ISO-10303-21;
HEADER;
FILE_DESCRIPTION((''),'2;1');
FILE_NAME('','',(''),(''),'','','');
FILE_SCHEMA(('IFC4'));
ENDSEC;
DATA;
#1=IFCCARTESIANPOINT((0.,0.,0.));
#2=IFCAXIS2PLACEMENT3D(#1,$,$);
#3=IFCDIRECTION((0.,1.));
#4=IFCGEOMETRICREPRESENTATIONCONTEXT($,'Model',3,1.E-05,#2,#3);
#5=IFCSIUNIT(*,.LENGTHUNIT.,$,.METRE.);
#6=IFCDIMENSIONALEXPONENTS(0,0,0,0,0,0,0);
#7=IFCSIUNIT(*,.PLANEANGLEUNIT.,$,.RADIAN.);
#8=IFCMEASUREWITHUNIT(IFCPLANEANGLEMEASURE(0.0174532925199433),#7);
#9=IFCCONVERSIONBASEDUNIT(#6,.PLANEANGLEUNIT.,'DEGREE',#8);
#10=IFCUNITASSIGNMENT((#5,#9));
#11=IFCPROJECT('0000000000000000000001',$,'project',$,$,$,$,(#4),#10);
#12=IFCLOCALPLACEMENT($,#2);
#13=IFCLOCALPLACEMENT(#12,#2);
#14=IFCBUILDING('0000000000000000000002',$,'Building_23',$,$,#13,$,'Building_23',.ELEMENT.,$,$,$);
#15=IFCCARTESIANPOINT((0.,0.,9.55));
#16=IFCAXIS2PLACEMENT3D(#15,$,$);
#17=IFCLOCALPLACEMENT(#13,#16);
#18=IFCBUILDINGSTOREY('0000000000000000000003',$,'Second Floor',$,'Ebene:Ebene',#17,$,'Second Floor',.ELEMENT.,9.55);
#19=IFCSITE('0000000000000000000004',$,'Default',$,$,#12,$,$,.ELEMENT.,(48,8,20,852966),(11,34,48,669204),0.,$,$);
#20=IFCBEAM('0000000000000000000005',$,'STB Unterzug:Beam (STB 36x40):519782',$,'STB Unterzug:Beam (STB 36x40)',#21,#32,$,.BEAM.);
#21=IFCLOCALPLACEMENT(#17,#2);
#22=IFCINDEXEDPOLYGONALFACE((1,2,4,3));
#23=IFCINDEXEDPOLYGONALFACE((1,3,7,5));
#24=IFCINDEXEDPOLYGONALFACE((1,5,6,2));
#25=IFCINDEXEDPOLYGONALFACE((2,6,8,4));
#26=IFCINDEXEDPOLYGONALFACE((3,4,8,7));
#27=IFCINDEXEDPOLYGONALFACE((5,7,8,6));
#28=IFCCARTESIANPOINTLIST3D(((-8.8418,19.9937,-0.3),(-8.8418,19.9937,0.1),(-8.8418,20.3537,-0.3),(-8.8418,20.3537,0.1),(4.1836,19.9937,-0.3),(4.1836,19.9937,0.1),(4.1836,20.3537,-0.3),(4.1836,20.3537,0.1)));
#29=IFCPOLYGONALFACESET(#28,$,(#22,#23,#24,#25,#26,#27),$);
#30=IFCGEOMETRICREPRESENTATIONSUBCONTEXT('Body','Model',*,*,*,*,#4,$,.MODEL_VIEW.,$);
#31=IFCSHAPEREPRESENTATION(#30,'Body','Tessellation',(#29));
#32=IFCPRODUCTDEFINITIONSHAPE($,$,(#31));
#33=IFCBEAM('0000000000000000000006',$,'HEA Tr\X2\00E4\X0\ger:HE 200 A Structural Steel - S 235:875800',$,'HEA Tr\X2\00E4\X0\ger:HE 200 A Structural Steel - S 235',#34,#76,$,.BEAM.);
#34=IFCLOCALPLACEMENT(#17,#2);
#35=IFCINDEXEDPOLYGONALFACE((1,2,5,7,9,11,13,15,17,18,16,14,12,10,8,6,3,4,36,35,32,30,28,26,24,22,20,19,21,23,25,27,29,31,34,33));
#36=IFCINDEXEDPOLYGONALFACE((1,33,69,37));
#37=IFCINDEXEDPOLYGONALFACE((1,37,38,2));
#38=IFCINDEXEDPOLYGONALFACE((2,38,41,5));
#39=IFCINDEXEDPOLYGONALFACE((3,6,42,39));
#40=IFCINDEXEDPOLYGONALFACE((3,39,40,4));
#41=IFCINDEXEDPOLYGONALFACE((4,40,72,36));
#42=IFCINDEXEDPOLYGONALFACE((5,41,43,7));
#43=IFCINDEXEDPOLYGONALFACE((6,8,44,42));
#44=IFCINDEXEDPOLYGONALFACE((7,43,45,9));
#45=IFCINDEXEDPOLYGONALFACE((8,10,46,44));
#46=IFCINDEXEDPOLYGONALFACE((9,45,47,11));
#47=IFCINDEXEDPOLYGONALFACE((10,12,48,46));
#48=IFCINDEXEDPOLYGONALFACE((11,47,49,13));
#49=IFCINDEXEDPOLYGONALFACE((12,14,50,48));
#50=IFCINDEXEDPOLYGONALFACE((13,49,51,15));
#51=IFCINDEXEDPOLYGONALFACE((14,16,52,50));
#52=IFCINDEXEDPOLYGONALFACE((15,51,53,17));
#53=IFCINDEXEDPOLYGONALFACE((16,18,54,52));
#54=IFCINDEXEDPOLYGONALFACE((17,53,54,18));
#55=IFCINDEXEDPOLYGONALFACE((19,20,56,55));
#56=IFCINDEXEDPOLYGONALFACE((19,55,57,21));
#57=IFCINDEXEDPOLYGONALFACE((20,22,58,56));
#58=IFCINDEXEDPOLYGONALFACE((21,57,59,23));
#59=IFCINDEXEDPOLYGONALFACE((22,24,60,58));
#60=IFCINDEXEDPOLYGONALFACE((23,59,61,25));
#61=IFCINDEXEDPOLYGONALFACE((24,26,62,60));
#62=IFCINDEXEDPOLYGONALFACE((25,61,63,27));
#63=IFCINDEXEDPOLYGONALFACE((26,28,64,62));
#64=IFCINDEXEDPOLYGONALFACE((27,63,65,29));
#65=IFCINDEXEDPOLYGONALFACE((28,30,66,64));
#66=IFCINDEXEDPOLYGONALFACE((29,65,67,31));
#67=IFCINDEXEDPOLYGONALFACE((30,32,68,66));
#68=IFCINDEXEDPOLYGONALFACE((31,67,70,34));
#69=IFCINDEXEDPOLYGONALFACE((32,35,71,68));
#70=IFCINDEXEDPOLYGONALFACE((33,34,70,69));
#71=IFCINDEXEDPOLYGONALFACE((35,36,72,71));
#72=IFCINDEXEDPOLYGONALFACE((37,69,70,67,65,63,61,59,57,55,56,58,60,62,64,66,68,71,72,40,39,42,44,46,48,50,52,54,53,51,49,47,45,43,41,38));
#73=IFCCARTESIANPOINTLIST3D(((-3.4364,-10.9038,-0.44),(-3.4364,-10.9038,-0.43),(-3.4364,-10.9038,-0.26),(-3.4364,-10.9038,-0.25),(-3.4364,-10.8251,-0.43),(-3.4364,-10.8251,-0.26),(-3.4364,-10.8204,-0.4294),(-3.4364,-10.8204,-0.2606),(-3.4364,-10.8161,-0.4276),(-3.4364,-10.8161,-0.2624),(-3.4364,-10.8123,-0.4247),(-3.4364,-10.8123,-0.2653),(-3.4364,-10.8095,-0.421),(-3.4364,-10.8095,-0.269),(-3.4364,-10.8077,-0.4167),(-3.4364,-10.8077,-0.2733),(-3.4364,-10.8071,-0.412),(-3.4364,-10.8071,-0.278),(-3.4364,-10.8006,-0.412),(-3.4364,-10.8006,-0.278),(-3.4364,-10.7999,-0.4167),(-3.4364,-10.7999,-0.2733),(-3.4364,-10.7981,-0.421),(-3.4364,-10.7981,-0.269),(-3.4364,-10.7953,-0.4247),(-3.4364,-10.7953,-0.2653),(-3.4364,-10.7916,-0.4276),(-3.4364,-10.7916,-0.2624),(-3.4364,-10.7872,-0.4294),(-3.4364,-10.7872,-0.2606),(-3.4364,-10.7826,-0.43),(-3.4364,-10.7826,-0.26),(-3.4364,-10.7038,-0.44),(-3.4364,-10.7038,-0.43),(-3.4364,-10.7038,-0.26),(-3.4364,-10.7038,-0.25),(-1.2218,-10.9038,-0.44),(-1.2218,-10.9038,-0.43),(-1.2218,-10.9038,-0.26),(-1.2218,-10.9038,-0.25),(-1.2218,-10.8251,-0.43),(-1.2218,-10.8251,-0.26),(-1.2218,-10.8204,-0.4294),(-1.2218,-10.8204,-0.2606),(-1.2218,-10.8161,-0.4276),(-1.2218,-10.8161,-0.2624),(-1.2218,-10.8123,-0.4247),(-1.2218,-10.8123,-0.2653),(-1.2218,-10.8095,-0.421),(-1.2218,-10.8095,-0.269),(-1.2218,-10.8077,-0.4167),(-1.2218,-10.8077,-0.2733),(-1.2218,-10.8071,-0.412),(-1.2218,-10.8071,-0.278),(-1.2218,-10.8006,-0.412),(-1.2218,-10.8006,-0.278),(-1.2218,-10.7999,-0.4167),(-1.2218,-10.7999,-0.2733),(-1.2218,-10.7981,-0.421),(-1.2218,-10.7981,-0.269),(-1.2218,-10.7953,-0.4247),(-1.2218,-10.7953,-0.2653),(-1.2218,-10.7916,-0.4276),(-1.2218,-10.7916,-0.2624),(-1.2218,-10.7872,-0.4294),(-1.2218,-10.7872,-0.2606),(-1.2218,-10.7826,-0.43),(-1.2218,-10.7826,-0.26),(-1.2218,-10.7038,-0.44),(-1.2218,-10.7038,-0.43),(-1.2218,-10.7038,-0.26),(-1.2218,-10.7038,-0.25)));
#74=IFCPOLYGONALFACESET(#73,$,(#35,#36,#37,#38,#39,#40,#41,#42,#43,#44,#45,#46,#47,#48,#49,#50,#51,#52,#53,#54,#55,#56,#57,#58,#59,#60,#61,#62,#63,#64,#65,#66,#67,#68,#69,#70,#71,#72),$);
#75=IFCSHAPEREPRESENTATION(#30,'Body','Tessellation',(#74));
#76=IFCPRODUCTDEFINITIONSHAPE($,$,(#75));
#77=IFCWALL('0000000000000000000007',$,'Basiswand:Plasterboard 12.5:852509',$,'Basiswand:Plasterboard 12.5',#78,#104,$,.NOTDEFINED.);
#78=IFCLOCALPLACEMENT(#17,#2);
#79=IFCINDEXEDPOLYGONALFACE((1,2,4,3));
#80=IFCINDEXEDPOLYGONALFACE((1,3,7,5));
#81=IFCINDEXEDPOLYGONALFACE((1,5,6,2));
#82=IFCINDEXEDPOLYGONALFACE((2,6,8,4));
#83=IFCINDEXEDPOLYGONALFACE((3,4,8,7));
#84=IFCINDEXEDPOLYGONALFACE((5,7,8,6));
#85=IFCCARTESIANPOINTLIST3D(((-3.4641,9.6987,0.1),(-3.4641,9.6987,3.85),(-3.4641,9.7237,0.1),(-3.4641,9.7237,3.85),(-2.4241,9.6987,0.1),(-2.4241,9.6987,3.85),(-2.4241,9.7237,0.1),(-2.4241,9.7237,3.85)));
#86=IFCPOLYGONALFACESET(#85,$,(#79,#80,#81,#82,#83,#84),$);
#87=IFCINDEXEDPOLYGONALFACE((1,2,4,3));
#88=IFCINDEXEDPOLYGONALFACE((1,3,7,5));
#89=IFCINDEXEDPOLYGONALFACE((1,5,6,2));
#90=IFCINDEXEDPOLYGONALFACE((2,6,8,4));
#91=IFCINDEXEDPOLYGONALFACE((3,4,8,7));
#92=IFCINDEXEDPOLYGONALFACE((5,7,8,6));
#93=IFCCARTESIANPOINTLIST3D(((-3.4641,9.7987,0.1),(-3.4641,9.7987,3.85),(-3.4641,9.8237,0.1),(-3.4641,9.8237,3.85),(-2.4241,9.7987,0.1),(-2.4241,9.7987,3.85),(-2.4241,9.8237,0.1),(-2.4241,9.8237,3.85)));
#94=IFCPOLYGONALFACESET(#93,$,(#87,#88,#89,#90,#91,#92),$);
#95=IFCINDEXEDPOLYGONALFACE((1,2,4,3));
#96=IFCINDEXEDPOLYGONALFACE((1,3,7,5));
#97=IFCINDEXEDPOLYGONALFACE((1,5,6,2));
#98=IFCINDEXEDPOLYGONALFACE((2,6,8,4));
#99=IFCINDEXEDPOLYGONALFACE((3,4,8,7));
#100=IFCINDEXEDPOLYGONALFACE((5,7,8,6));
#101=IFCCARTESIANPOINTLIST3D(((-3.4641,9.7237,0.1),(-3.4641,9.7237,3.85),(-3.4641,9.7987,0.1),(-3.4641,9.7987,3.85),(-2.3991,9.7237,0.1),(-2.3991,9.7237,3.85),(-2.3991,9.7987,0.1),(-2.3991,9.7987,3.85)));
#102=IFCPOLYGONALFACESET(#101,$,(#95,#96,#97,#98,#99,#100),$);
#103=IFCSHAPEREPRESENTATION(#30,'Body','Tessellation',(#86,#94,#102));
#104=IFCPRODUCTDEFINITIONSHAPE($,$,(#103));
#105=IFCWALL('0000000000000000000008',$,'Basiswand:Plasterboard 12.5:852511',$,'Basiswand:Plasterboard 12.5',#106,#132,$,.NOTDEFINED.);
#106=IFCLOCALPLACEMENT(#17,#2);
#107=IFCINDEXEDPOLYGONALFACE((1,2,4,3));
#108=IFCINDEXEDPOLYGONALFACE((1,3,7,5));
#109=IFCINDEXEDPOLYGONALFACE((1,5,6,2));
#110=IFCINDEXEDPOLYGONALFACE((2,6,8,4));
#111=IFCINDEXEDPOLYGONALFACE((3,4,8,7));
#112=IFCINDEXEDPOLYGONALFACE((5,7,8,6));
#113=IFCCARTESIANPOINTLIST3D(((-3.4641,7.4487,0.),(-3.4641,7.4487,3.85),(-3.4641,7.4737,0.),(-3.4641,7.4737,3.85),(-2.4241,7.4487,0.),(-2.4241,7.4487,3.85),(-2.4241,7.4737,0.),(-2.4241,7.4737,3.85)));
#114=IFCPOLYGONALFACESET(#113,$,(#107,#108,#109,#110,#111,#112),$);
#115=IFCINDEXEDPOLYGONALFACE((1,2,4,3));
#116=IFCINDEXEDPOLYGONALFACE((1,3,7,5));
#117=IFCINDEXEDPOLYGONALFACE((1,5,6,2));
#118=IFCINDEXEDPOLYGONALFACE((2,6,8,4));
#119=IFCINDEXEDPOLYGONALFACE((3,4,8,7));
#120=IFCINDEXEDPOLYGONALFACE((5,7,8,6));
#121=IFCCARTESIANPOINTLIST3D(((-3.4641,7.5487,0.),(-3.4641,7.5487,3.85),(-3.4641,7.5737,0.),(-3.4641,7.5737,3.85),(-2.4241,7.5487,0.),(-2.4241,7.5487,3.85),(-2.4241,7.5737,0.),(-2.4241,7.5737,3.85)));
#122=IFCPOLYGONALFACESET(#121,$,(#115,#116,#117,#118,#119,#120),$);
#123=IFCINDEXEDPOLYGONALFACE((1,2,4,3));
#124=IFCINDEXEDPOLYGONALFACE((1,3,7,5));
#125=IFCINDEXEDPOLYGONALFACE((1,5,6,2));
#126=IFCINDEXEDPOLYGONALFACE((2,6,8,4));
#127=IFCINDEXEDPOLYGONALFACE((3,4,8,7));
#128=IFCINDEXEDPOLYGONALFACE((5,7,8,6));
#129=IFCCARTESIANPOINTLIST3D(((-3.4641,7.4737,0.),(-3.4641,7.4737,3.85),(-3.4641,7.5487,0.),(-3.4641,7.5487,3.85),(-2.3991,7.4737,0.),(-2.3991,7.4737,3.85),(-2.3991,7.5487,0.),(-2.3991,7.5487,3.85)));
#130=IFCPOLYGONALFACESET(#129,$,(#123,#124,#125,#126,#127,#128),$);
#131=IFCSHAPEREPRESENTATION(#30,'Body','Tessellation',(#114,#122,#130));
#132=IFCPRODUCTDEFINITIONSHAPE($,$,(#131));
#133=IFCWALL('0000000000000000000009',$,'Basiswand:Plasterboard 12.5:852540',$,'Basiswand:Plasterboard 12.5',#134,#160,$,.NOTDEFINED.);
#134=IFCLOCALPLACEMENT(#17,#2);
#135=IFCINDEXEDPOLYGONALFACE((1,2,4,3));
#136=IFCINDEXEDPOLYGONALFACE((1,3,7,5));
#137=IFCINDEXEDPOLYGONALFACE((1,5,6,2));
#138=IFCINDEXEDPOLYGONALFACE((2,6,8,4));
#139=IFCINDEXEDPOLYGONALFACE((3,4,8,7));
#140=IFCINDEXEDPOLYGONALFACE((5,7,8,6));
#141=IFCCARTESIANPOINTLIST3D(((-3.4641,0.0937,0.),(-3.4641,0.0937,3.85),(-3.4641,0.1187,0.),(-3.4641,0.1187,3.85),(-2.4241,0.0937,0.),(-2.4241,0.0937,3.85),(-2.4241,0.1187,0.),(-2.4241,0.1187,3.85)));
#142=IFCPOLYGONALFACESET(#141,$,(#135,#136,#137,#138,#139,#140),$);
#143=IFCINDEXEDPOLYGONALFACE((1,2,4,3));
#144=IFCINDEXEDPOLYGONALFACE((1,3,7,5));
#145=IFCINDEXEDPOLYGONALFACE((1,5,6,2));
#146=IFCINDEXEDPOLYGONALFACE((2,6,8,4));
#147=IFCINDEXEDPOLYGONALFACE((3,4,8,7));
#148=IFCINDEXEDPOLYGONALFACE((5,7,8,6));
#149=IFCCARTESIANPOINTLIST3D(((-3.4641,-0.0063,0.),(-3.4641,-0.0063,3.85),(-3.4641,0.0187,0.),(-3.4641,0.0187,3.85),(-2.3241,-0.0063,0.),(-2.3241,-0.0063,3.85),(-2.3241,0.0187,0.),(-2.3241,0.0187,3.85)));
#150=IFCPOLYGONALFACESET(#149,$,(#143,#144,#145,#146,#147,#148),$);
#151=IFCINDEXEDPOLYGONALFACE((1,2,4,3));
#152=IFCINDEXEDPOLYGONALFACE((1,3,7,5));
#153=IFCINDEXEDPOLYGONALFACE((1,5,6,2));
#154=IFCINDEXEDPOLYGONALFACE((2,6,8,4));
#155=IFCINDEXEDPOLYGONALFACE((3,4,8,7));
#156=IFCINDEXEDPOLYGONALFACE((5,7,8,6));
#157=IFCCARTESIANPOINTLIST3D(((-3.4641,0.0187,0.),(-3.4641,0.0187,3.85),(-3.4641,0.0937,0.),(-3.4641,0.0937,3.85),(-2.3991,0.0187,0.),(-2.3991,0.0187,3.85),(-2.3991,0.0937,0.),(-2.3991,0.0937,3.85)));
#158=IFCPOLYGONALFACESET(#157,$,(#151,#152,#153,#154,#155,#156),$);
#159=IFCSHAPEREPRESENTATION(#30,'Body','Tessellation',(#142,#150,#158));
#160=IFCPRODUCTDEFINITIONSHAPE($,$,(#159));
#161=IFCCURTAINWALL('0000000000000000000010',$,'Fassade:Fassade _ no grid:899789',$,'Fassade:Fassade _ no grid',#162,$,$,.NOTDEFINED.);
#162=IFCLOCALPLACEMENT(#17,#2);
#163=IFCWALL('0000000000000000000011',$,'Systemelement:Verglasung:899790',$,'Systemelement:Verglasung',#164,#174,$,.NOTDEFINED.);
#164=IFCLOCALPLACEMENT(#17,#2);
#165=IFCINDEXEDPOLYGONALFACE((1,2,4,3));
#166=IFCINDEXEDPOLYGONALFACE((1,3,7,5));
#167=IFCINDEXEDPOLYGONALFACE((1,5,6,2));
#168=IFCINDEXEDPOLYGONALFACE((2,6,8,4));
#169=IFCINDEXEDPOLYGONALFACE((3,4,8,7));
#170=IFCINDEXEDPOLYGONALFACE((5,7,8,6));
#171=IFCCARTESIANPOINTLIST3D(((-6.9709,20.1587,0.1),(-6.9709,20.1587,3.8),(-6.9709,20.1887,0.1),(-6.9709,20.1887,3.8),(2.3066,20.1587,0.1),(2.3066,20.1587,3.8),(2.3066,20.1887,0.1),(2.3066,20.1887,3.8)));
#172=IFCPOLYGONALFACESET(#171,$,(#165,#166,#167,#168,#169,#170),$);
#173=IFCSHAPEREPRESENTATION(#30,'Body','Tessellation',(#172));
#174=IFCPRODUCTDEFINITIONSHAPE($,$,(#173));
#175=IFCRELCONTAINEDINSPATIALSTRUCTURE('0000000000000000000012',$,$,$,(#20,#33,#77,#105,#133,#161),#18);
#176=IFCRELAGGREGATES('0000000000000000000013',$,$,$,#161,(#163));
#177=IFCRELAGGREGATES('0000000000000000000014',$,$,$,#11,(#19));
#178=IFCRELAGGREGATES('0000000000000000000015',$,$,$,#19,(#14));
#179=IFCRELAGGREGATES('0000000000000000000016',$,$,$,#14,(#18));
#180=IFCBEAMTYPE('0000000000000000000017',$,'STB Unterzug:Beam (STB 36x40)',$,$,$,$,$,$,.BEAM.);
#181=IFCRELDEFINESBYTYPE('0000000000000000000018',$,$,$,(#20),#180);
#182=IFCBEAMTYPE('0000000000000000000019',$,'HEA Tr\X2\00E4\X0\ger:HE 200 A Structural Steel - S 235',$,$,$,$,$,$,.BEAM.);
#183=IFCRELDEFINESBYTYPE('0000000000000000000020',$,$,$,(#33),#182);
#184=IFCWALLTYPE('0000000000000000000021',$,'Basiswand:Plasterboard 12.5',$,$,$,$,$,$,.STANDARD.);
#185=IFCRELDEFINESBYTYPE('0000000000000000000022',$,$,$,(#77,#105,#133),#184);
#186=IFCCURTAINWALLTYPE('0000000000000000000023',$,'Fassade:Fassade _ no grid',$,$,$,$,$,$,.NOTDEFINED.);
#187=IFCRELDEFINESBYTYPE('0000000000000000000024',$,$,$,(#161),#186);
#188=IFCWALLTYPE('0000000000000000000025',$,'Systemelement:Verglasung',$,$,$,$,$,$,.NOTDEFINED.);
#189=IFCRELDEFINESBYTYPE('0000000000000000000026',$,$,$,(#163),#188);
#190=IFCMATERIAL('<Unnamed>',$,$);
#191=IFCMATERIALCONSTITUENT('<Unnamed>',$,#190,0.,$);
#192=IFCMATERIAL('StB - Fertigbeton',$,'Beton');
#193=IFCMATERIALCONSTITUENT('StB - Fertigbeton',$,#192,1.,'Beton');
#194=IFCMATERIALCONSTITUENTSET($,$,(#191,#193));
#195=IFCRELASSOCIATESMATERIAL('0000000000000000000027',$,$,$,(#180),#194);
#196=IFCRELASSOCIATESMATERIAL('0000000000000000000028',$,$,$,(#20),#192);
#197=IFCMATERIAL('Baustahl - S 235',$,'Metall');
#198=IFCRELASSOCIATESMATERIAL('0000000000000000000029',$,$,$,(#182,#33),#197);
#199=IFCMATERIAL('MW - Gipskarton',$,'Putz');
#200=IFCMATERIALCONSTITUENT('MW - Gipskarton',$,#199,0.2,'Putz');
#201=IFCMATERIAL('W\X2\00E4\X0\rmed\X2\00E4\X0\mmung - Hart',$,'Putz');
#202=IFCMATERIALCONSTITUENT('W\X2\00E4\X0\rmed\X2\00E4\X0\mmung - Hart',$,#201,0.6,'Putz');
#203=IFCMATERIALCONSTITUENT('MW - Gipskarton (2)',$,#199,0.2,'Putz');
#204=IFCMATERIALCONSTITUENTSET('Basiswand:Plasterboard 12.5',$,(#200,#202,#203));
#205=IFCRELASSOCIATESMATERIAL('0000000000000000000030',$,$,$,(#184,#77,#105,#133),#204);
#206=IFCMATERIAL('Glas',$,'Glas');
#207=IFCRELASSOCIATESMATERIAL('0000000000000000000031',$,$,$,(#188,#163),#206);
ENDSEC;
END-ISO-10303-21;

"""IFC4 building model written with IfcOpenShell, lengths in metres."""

from ifc_helpers import new_model, entity, si_unit, converted_unit, direction, frame, origin, place, context, subcontext, project, spatial, line, arc, indexed_curve, outline, extrude, source, transform, mapped, material, constituent, constituent_set, type_object, type_shapes, element, aggregate, save


model = new_model("IFC4")

# Units and contexts
model_context = context("Model", 3, precision=1e-05, world=origin(), true_north=direction((0.0, 1.0)))
body_context = subcontext(model_context, "Body", "Model", "MODEL_VIEW")
ifc_project = project(units=[si_unit("LENGTHUNIT", "METRE"), converted_unit("PLANEANGLEUNIT", "DEGREE", entity("IfcPlaneAngleMeasure", 0.0174532925199433), si_unit("PLANEANGLEUNIT", "RADIAN"), dimensions=[0, 0, 0, 0, 0, 0, 0])], contexts=[model_context])

# Site, building, storey
site_placement = place(None, origin())
site = spatial("IfcSite", under=ifc_project, at=site_placement, Name="Default", CompositionType="ELEMENT", RefLatitude=(48, 8, 20, 852966), RefLongitude=(11, 34, 48, 669204), RefElevation=0.0)
building_placement = place(site_placement, origin())
building = spatial("IfcBuilding", under=site, at=building_placement, Name="Building_23", LongName="Building_23", CompositionType="ELEMENT")
storey_placement = place(building_placement, frame((0.0, 0.0, 9.55)))
storey = spatial("IfcBuildingStorey", under=building, at=storey_placement, Name="Second Floor", ObjectType="Ebene:Ebene", LongName="Second Floor", CompositionType="ELEMENT", Elevation=9.55)

# Beams
ifc_material_1 = material(Name="StB - Fertigbeton", Category="Beton")
ifc_material_2 = material(Name="<Unnamed>")
ifc_constituent_1 = constituent(ifc_material_2, Name="<Unnamed>", fraction=0.0)
ifc_constituent_2 = constituent(ifc_material_1, Name="StB - Fertigbeton", Category="Beton", fraction=1.0)
ifc_constituent_set_1 = constituent_set(constituents=[ifc_constituent_1, ifc_constituent_2])
beam_type_1 = type_object("IfcBeamType", Name="STB Unterzug:Beam (STB 36x40)", PredefinedType="BEAM", material=ifc_constituent_set_1)
shared_shape_1 = source(origin(), body_context, "Body", "SweptSolid", [
    extrude(outline(indexed_curve([(-0.2, -0.18), (0.2, -0.18), (0.2, 0.18), (-0.2, 0.18), (-0.2, -0.18)], self_intersect=False)), frame((-8.8418, 20.1737, 9.45), z_axis=(1.0, 0.0, 0.0), x_axis=(0.0, 0.0, -1.0)), (0.0, 0.0, 1.0), 13.0254),
])
type_shapes(beam_type_1, [shared_shape_1])
beam_1_placement = place(storey_placement, frame((0.0, 0.0, -9.55)))
element("IfcBeam", 1, at=beam_1_placement, inside=storey, type_object=beam_type_1, material=ifc_material_1, Name="STB Unterzug:Beam (STB 36x40):519782", ObjectType="STB Unterzug:Beam (STB 36x40)", PredefinedType="BEAM", context=body_context, shape_type="MappedRepresentation", body=[
    mapped(shared_shape_1, transform((0.0, 0.0, 0.0), scale=1.0)),
])
ifc_material_3 = material(Name="Baustahl - S 235", Category="Metall")
beam_type_2 = type_object("IfcBeamType", Name="HEA Träger:HE 200 A Structural Steel - S 235", PredefinedType="BEAM", material=ifc_material_3)
shared_shape_2 = source(origin(), body_context, "Body", "SweptSolid", [
    extrude(outline(indexed_curve([(-0.1, -0.085), (-0.1, -0.095), (0.1, -0.095), (0.1, -0.085), (0.0213, -0.085), (0.0085, -0.0797), (0.0033, -0.067), (0.0033, 0.067), (0.0085, 0.0797), (0.0213, 0.085), (0.1, 0.085), (0.1, 0.095), (-0.1, 0.095), (-0.1, 0.085), (-0.0213, 0.085), (-0.0085, 0.0797), (-0.0033, 0.067), (-0.0033, -0.067), (-0.0085, -0.0797), (-0.0213, -0.085)], segments=[line(1, 2, 3, 4, 5), arc(5, 6, 7), line(7, 8), arc(8, 9, 10), line(10, 11, 12, 13, 14, 15), arc(15, 16, 17), line(17, 18), arc(18, 19, 20), line(20, 1)], self_intersect=False)), frame((-1.1073, 0.0, 0.0), z_axis=(-1.0, 0.0, 0.0), x_axis=(0.0, -1.0, 0.0)), (0.0, 0.0, -1.0), 2.2146),
])
type_shapes(beam_type_2, [shared_shape_2])
beam_2_placement = place(storey_placement, frame((-2.3291, -10.8038, -0.345), z_axis=(0.0, 0.0, 1.0), x_axis=(-1.0, 0.0, 0.0)))
element("IfcBeam", 2, at=beam_2_placement, inside=storey, type_object=beam_type_2, material=ifc_material_3, Name="HEA Träger:HE 200 A Structural Steel - S 235:875800", ObjectType="HEA Träger:HE 200 A Structural Steel - S 235", PredefinedType="BEAM", context=body_context, shape_type="MappedRepresentation", body=[
    mapped(shared_shape_2, transform((0.0, 0.0, 0.0), scale=1.0)),
])

# Shared definitions
ifc_material_4 = material(Name="Wärmedämmung - Hart", Category="Putz")

# Walls
ifc_material_5 = material(Name="MW - Gipskarton", Category="Putz")
ifc_constituent_3 = constituent(ifc_material_5, Name="MW - Gipskarton", Category="Putz", fraction=0.2)
ifc_constituent_4 = constituent(ifc_material_4, Name="Wärmedämmung - Hart", Category="Putz", fraction=0.6)
ifc_constituent_5 = constituent(ifc_material_5, Name="MW - Gipskarton (2)", Category="Putz", fraction=0.2)
ifc_constituent_set_2 = constituent_set(constituents=[ifc_constituent_3, ifc_constituent_4, ifc_constituent_5], Name="Basiswand:Plasterboard 12.5")
wall_type_1 = type_object("IfcWallType", Name="Basiswand:Plasterboard 12.5", PredefinedType="STANDARD", material=ifc_constituent_set_2)
wall_1_placement = place(storey_placement, frame((-3.4491, 9.7612, 0.1)))
element("IfcWall", 3, at=wall_1_placement, inside=storey, type_object=wall_type_1, material=ifc_constituent_set_2, Name="Basiswand:Plasterboard 12.5:852509", ObjectType="Basiswand:Plasterboard 12.5", PredefinedType="NOTDEFINED", context=body_context, shape_type="SweptSolid", body=[
    extrude(outline(indexed_curve([(-0.0125, -0.52), (0.0125, -0.52), (0.0125, 0.52), (-0.0125, 0.52), (-0.0125, -0.52)], self_intersect=False)), frame((0.505, -0.05, 0.0), z_axis=(0.0, 0.0, 1.0), x_axis=(0.0, 1.0, 0.0)), (0.0, 0.0, 1.0), 3.75),
    extrude(outline(indexed_curve([(-0.0125, -0.52), (0.0125, -0.52), (0.0125, 0.52), (-0.0125, 0.52), (-0.0125, -0.52)], self_intersect=False)), frame((0.505, 0.05, 0.0), z_axis=(0.0, 0.0, 1.0), x_axis=(0.0, -1.0, 0.0)), (0.0, 0.0, 1.0), 3.75),
    extrude(outline(indexed_curve([(-0.5325, -0.0375), (0.5325, -0.0375), (0.5325, 0.0375), (-0.5325, 0.0375), (-0.5325, -0.0375)], self_intersect=False)), frame((0.5175, 0.0, 0.0), z_axis=(0.0, 0.0, 1.0), x_axis=(-1.0, 0.0, 0.0)), (0.0, 0.0, 1.0), 3.75),
])
wall_2_placement = place(storey_placement, frame((-3.4491, 7.5112, 0.0)))
element("IfcWall", 4, at=wall_2_placement, inside=storey, type_object=wall_type_1, material=ifc_constituent_set_2, Name="Basiswand:Plasterboard 12.5:852511", ObjectType="Basiswand:Plasterboard 12.5", PredefinedType="NOTDEFINED", context=body_context, shape_type="SweptSolid", body=[
    extrude(outline(indexed_curve([(-0.0125, -0.52), (0.0125, -0.52), (0.0125, 0.52), (-0.0125, 0.52), (-0.0125, -0.52)], self_intersect=False)), frame((0.505, -0.05, 0.0), z_axis=(0.0, 0.0, 1.0), x_axis=(0.0, 1.0, 0.0)), (0.0, 0.0, 1.0), 3.85),
    extrude(outline(indexed_curve([(-0.0125, -0.52), (0.0125, -0.52), (0.0125, 0.52), (-0.0125, 0.52), (-0.0125, -0.52)], self_intersect=False)), frame((0.505, 0.05, 0.0), z_axis=(0.0, 0.0, 1.0), x_axis=(0.0, -1.0, 0.0)), (0.0, 0.0, 1.0), 3.85),
    extrude(outline(indexed_curve([(-0.5325, -0.0375), (0.5325, -0.0375), (0.5325, 0.0375), (-0.5325, 0.0375), (-0.5325, -0.0375)], self_intersect=False)), frame((0.5175, 0.0, 0.0)), (0.0, 0.0, 1.0), 3.85),
])

# Wall
wall_3_placement = place(storey_placement, frame((-2.4241, 0.0562, 0.0), z_axis=(0.0, 0.0, 1.0), x_axis=(-1.0, 0.0, 0.0)))
element("IfcWall", 5, at=wall_3_placement, inside=storey, type_object=wall_type_1, material=ifc_constituent_set_2, Name="Basiswand:Plasterboard 12.5:852540", ObjectType="Basiswand:Plasterboard 12.5", PredefinedType="NOTDEFINED", context=body_context, shape_type="SweptSolid", body=[
    extrude(outline(indexed_curve([(-0.0125, -0.52), (0.0125, -0.52), (0.0125, 0.52), (-0.0125, 0.52), (-0.0125, -0.52)], self_intersect=False)), frame((0.52, -0.05, 0.0), z_axis=(0.0, 0.0, 1.0), x_axis=(0.0, 1.0, 0.0)), (0.0, 0.0, 1.0), 3.85),
    extrude(outline(indexed_curve([(-0.0125, -0.57), (0.0125, -0.57), (0.0125, 0.57), (-0.0125, 0.57), (-0.0125, -0.57)], self_intersect=False)), frame((0.47, 0.05, 0.0), z_axis=(0.0, 0.0, 1.0), x_axis=(0.0, -1.0, 0.0)), (0.0, 0.0, 1.0), 3.85),
    extrude(outline(indexed_curve([(-0.5325, -0.0375), (0.5325, -0.0375), (0.5325, 0.0375), (-0.5325, 0.0375), (-0.5325, -0.0375)], self_intersect=False)), frame((0.5075, 0.0, 0.0)), (0.0, 0.0, 1.0), 3.85),
])

# Curtain wall, wall
curtain_wall_type = type_object("IfcCurtainWallType", Name="Fassade:Fassade _ no grid", PredefinedType="NOTDEFINED")
curtain_wall_placement = place(storey_placement, frame((0.0, 0.0, -9.55)))
curtain_wall = element("IfcCurtainWall", 6, at=curtain_wall_placement, inside=storey, type_object=curtain_wall_type, Name="Fassade:Fassade _ no grid:899789", ObjectType="Fassade:Fassade _ no grid", PredefinedType="NOTDEFINED")
ifc_material_6 = material(Name="Glas", Category="Glas")
wall_type_2 = type_object("IfcWallType", Name="Systemelement:Verglasung", PredefinedType="NOTDEFINED", material=ifc_material_6)
shared_shape_3 = source(origin(), body_context, "Body", "SweptSolid", [
    extrude(outline(indexed_curve([(-0.015, -4.6388), (0.015, -4.6388), (0.015, 4.6388), (-0.015, 4.6388), (-0.015, -4.6388)], self_intersect=False)), frame((0.0, 0.0, 0.0), z_axis=(0.0, 0.0, 1.0), x_axis=(0.0, 1.0, 0.0)), (0.0, 0.0, 1.0), 3.7),
])
type_shapes(wall_type_2, [shared_shape_3])
wall_4_placement = place(storey_placement, frame((-2.3321, 20.1737, 0.1)))
wall_4 = element("IfcWall", 7, at=wall_4_placement, type_object=wall_type_2, material=ifc_material_6, Name="Systemelement:Verglasung:899790", ObjectType="Systemelement:Verglasung", PredefinedType="NOTDEFINED", context=body_context, shape_type="MappedRepresentation", body=[
    mapped(shared_shape_3, transform((0.0, 0.0, 0.0), scale=1.0)),
])
aggregate(curtain_wall, [wall_4])

save(model, "model.ifc")
